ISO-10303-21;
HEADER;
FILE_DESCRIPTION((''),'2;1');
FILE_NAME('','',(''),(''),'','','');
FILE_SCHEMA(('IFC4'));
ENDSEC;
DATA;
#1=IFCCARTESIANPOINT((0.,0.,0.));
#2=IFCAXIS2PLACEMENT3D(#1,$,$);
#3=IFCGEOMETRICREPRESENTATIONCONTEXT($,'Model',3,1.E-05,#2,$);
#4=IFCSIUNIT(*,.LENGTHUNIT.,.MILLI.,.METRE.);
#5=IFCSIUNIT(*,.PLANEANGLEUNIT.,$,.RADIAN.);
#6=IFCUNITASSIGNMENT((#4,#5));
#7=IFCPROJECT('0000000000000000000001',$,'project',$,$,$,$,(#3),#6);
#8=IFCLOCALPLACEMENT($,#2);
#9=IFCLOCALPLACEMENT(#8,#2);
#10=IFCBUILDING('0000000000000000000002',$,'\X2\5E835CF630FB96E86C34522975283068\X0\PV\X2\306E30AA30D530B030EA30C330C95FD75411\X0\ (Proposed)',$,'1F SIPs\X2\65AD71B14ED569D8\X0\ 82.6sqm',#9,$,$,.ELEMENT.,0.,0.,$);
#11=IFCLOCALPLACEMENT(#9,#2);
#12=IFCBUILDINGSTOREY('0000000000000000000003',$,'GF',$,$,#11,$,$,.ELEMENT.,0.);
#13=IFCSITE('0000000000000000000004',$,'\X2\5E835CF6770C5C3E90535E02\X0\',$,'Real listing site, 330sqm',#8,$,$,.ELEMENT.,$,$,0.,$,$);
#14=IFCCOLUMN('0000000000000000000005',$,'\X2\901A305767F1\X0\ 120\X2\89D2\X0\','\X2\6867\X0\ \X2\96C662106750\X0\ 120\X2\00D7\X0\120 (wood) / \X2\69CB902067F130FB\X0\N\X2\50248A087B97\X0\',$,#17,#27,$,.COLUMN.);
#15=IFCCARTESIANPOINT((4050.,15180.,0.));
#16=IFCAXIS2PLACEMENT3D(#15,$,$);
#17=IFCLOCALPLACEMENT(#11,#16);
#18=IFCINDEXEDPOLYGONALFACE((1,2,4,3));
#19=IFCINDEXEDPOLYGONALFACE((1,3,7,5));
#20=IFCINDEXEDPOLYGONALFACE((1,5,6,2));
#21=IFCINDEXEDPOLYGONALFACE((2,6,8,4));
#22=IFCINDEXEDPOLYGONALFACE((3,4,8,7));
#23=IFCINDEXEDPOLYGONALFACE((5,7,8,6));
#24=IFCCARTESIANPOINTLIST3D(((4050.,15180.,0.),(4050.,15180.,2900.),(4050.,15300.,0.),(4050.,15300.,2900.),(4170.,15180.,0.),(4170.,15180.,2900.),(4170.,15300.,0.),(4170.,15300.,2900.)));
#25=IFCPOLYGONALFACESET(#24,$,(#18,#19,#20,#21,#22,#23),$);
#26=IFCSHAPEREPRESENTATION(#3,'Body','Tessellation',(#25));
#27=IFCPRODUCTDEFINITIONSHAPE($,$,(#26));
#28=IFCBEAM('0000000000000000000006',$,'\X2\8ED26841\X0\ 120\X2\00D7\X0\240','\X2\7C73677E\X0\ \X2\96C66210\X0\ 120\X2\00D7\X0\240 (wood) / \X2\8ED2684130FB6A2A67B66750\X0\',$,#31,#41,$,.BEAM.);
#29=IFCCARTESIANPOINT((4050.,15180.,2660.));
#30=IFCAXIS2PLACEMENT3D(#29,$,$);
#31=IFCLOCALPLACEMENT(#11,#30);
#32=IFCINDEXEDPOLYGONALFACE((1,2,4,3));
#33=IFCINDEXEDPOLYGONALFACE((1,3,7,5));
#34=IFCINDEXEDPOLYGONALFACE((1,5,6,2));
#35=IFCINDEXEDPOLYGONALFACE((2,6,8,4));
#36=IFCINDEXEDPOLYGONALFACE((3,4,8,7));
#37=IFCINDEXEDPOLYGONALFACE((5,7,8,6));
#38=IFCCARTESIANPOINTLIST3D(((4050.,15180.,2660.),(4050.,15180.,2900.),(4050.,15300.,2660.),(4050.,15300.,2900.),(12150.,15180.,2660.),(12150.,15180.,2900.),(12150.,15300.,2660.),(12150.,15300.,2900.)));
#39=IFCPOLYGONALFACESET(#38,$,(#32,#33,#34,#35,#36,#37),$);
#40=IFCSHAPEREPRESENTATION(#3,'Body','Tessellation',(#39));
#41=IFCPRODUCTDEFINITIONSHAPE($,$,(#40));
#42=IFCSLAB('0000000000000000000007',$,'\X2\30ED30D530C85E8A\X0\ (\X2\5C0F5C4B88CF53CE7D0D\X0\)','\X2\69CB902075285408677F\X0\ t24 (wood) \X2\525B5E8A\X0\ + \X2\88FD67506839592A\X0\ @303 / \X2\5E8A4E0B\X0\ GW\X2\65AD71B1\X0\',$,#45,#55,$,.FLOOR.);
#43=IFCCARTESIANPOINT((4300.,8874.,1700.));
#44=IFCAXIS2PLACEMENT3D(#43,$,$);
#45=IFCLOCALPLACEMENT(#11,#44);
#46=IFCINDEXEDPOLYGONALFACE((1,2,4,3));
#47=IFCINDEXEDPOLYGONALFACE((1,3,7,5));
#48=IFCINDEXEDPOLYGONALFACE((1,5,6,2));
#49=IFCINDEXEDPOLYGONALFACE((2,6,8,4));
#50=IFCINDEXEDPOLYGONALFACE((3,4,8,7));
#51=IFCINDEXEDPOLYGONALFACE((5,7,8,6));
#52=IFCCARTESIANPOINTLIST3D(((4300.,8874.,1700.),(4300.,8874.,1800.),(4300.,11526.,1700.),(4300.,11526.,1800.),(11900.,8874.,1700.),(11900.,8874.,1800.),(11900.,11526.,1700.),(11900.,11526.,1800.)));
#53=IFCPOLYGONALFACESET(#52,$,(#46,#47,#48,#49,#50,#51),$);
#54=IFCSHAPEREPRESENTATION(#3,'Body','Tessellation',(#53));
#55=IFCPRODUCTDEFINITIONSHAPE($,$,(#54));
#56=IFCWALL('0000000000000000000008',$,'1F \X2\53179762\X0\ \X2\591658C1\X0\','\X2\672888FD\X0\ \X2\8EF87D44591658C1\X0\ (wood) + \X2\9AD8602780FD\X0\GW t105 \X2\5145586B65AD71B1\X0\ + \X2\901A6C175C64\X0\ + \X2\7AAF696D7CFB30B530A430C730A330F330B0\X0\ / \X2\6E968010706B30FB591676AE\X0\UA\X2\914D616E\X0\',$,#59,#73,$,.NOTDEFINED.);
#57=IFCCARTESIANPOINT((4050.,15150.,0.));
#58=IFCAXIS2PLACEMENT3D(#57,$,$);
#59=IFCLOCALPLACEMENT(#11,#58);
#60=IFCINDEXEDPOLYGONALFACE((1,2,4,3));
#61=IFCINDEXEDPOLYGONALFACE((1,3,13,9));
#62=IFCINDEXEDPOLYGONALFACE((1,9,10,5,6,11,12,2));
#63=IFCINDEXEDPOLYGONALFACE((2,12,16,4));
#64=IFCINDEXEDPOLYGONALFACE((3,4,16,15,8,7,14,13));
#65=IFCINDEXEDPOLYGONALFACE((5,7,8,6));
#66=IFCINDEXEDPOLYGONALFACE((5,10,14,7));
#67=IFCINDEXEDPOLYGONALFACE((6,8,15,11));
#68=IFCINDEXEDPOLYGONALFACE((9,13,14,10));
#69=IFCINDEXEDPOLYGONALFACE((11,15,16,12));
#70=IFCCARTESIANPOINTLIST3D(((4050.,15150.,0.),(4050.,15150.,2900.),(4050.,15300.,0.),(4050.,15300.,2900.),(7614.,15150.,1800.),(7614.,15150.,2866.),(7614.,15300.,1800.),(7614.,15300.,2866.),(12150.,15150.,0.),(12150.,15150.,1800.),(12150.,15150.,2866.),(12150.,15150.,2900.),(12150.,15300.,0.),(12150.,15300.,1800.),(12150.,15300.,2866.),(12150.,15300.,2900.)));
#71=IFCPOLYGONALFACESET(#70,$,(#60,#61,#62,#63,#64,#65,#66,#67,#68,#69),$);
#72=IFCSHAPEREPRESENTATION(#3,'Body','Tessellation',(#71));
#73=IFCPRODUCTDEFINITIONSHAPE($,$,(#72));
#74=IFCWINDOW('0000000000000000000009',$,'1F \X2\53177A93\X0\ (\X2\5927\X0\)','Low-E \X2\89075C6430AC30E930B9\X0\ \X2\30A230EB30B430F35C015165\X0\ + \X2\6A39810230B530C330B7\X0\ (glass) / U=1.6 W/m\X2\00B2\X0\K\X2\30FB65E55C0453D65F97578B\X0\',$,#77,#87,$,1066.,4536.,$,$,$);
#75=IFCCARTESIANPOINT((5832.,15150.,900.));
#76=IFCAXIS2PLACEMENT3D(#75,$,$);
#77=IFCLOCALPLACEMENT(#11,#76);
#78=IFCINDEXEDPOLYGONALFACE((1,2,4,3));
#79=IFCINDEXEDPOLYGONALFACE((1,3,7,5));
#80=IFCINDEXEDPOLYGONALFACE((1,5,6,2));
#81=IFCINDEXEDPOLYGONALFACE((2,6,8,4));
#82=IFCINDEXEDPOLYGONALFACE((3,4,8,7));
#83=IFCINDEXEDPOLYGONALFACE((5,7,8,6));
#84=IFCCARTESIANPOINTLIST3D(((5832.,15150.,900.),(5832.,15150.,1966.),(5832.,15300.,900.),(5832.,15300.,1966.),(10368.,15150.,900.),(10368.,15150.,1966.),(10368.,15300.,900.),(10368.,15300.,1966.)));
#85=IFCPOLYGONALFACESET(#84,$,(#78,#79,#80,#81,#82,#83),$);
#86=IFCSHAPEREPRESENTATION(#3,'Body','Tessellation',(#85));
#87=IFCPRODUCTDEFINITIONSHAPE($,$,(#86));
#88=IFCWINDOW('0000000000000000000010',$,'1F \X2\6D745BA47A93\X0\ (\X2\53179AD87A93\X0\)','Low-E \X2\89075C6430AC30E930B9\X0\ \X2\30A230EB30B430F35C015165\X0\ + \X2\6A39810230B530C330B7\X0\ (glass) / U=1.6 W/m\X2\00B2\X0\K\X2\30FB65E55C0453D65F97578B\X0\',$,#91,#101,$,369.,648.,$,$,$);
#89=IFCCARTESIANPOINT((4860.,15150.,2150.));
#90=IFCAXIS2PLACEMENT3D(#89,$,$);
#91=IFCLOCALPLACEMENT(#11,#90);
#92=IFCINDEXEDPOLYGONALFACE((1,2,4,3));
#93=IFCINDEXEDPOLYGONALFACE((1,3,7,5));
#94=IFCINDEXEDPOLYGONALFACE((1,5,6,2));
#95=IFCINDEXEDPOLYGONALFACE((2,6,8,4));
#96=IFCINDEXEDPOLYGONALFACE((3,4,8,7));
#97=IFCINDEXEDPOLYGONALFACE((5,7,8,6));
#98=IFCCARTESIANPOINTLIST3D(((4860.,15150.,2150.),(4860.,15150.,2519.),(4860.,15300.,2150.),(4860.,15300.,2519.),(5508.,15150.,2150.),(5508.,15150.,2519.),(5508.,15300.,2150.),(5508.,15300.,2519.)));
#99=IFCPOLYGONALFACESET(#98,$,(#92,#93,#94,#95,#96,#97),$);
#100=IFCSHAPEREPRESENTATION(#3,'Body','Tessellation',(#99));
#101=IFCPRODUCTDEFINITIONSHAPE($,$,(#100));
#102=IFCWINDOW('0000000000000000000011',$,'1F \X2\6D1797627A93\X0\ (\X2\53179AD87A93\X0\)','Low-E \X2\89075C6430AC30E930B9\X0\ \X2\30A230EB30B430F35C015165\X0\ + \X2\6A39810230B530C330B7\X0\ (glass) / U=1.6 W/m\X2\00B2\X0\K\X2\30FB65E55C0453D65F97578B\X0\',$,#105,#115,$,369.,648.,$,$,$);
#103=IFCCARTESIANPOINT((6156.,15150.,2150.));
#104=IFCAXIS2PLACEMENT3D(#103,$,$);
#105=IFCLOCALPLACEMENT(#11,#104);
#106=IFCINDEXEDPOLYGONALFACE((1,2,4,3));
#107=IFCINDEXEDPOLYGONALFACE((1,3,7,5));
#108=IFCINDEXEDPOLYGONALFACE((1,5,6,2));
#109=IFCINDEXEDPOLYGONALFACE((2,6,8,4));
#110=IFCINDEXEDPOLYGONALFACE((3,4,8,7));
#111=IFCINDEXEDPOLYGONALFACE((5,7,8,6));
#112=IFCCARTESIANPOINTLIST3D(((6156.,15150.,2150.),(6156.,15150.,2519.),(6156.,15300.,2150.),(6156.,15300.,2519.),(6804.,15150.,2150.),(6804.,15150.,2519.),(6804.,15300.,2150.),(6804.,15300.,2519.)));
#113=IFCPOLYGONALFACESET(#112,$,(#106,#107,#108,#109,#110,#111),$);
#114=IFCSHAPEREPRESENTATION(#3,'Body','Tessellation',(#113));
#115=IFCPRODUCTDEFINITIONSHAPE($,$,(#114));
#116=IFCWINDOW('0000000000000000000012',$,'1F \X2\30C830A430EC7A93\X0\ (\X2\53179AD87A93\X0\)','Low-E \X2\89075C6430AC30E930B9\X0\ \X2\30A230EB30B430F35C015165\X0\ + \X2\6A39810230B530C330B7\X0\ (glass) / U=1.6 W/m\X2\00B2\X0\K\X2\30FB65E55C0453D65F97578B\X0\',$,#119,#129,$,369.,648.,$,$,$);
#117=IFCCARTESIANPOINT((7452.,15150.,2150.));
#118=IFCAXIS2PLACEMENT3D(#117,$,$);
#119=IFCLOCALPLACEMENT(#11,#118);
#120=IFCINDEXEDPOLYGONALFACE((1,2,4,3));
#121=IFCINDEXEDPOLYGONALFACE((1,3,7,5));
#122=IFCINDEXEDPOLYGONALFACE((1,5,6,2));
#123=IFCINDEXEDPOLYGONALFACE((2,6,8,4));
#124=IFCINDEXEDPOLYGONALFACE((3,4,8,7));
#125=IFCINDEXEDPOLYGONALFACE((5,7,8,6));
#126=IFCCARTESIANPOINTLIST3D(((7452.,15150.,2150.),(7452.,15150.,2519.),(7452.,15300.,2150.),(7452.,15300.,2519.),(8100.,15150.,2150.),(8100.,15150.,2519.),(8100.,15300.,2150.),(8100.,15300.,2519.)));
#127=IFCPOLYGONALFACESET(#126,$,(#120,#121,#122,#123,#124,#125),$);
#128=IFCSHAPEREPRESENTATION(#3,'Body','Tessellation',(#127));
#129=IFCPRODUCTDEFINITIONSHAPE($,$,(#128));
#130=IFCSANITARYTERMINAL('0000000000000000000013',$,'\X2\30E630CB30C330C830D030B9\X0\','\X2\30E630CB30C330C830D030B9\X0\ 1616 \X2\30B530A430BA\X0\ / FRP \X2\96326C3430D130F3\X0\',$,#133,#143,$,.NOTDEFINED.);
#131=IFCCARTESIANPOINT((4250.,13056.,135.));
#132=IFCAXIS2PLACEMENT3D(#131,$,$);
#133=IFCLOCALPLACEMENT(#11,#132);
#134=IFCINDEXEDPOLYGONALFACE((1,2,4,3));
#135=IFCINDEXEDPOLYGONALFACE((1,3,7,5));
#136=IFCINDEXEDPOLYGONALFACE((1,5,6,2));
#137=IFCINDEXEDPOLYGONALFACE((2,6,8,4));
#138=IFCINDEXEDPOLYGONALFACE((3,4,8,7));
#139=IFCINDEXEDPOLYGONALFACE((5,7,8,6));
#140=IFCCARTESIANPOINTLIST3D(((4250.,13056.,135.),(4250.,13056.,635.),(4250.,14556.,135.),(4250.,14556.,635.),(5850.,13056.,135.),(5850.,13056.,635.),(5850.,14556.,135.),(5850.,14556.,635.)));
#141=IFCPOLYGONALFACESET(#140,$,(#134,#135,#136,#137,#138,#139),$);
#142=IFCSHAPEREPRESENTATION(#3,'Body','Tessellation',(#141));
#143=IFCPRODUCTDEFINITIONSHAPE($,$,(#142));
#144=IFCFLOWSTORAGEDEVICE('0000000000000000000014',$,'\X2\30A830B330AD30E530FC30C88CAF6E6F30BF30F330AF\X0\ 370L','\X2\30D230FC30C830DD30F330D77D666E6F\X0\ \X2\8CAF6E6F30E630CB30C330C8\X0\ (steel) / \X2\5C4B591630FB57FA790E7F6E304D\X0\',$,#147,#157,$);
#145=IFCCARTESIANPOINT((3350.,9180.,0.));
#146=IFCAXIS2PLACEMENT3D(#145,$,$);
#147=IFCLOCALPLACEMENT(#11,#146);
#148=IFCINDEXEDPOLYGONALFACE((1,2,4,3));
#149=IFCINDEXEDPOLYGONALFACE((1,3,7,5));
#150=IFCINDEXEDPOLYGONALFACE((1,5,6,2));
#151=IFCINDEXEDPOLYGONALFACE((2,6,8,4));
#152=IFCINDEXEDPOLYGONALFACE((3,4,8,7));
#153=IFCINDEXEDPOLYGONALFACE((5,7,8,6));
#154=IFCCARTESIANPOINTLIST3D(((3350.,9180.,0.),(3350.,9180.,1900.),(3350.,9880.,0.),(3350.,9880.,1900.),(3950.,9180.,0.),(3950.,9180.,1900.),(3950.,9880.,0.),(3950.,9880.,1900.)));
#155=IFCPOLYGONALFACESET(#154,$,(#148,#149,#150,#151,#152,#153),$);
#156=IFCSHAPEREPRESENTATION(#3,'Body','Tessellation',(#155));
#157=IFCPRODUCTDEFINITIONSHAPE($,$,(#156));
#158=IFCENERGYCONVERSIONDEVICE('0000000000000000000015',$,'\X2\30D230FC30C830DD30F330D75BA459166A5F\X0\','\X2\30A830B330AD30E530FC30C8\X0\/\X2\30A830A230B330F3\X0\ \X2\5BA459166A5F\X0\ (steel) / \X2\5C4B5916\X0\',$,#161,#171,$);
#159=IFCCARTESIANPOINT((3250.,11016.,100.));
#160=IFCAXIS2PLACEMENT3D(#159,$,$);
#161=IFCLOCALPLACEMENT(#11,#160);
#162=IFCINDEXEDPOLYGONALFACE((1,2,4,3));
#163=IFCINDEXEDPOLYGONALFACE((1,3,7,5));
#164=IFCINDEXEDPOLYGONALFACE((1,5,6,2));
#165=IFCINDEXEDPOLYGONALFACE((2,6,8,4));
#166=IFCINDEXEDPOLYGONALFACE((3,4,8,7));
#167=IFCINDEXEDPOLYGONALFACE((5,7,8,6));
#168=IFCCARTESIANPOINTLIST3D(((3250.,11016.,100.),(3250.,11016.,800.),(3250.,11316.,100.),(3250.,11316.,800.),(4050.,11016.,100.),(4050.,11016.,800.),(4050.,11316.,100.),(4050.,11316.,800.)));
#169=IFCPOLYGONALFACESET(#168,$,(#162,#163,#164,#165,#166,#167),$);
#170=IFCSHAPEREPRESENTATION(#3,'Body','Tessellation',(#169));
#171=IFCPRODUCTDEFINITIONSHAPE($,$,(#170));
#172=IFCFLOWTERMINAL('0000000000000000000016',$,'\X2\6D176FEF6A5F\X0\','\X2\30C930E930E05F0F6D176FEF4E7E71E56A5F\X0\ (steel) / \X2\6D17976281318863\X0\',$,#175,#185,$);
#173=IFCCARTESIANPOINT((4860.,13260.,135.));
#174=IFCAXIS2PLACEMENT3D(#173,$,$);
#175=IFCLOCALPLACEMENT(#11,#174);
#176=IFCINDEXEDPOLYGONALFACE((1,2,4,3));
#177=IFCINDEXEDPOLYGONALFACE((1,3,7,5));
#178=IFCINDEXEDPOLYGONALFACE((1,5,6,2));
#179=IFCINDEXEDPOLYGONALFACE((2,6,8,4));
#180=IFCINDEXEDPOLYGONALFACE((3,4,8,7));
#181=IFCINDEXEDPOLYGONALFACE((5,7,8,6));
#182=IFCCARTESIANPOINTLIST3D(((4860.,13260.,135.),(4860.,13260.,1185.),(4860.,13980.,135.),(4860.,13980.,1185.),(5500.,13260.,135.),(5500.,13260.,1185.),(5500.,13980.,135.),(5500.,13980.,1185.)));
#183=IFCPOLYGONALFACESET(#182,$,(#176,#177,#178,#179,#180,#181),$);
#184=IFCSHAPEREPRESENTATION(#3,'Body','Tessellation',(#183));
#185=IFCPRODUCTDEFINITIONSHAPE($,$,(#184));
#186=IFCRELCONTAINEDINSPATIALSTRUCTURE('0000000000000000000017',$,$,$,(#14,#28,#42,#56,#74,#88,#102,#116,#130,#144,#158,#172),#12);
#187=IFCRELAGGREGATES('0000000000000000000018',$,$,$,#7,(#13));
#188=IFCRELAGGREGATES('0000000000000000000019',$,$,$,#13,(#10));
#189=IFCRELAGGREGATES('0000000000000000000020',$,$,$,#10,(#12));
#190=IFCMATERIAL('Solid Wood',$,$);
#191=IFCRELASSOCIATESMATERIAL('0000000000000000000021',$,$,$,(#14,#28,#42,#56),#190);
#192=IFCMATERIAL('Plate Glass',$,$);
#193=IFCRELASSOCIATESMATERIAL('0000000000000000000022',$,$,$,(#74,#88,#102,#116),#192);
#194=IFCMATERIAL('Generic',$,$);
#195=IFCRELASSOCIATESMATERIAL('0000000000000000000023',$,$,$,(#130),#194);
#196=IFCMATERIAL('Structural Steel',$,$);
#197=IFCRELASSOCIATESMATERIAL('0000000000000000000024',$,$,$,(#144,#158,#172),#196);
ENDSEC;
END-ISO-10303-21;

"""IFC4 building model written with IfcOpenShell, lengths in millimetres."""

from ifc_helpers import new_model, si_unit, frame, frame_2d, origin, place, context, project, spatial, rectangle, extrude, material, element, fill, save


model = new_model("IFC4")

# Units and contexts
model_context = context("Model", 3, precision=1e-05, world=origin())
ifc_project = project(units=[si_unit("LENGTHUNIT", "METRE", prefix="MILLI"), si_unit("PLANEANGLEUNIT", "RADIAN")], contexts=[model_context])

# Site, building, storey
site_placement = place(None, origin())
site = spatial("IfcSite", under=ifc_project, at=site_placement, Name="広島県尾道市", ObjectType="Real listing site, 330sqm", CompositionType="ELEMENT", RefElevation=0.0)
building_placement = place(site_placement, origin())
building = spatial("IfcBuilding", under=site, at=building_placement, Name="広島・雨水利用とPVのオフグリッド志向 (Proposed)", ObjectType="1F SIPs断熱仕様 82.6sqm", CompositionType="ELEMENT", ElevationOfRefHeight=0.0, ElevationOfTerrain=0.0)
storey_placement = place(building_placement, origin())
storey = spatial("IfcBuildingStorey", under=building, at=storey_placement, Name="GF", CompositionType="ELEMENT", Elevation=0.0)

# Column
ifc_material_1 = material(Name="Solid Wood")
column_1_placement = place(storey_placement, frame((4050.0, 15180.0, 0.0)))
element("IfcColumn", 1, at=column_1_placement, inside=storey, material=ifc_material_1, Name="通し柱 120角", Description="桧 集成材 120×120 (wood) / 構造柱・N値計算", PredefinedType="COLUMN", context=model_context, shape_type="SweptSolid", body=[
    extrude(rectangle(XDim=120.0, YDim=120.0, at=frame_2d((60.0, 60.0))), frame((4050.0, 15180.0, 0.0)), (0.0, 0.0, 1.0), 2900.0),
])

# Beam
beam_1_placement = place(storey_placement, frame((4050.0, 15180.0, 2660.0)))
element("IfcBeam", 2, at=beam_1_placement, inside=storey, material=ifc_material_1, Name="軒桁 120×240", Description="米松 集成 120×240 (wood) / 軒桁・横架材", PredefinedType="BEAM", context=model_context, shape_type="SweptSolid", body=[
    extrude(rectangle(XDim=8100.0, YDim=120.0, at=frame_2d((4050.0, 60.0))), frame((4050.0, 15180.0, 2660.0)), (0.0, 0.0, 1.0), 240.0),
])

# Slab
slab_placement = place(storey_placement, frame((4300.0, 8874.0, 1700.0)))
element("IfcSlab", 3, at=slab_placement, inside=storey, material=ifc_material_1, Name="ロフト床 (小屋裏収納)", Description="構造用合板 t24 (wood) 剛床 + 製材根太 @303 / 床下 GW断熱", PredefinedType="FLOOR", context=model_context, shape_type="SweptSolid", body=[
    extrude(rectangle(XDim=7600.0, YDim=2652.0, at=frame_2d((3800.0, 1326.0))), frame((4300.0, 8874.0, 1700.0)), (0.0, 0.0, 1.0), 100.0),
])

# Wall, openings, windows
wall_1_placement = place(storey_placement, frame((4050.0, 15150.0, 0.0)))
wall_1 = element("IfcWall", 4, at=wall_1_placement, inside=storey, material=ifc_material_1, Name="1F 北面 外壁", Description="木製 軸組外壁 (wood) + 高性能GW t105 充填断熱 + 通気層 + 窯業系サイディング / 準耐火・外皮UA配慮", PredefinedType="NOTDEFINED", context=model_context, shape_type="SweptSolid", body=[
    extrude(rectangle(XDim=8100.0, YDim=150.0, at=frame_2d((4050.0, 75.0))), frame((4050.0, 15150.0, 0.0)), (0.0, 0.0, 1.0), 2900.0),
])
opening_1_placement = place(storey_placement, frame((5832.0, 15150.0, 900.0)))
opening_1 = element("IfcOpeningElement", 5, at=opening_1_placement, cuts=wall_1, PredefinedType="NOTDEFINED", context=model_context, shape_type="SweptSolid", body=[
    extrude(rectangle(XDim=4536.0, YDim=150.0, at=frame_2d((2268.0, 75.0))), frame((5832.0, 15150.0, 900.0)), (0.0, 0.0, 1.0), 1066.0),
])
opening_2_placement = place(storey_placement, frame((4860.0, 15150.0, 2150.0)))
opening_2 = element("IfcOpeningElement", 6, at=opening_2_placement, cuts=wall_1, PredefinedType="NOTDEFINED", context=model_context, shape_type="SweptSolid", body=[
    extrude(rectangle(XDim=648.0, YDim=150.0, at=frame_2d((324.0, 75.0))), frame((4860.0, 15150.0, 2150.0)), (0.0, 0.0, 1.0), 369.0),
])
opening_3_placement = place(storey_placement, frame((6156.0, 15150.0, 2150.0)))
opening_3 = element("IfcOpeningElement", 7, at=opening_3_placement, cuts=wall_1, PredefinedType="NOTDEFINED", context=model_context, shape_type="SweptSolid", body=[
    extrude(rectangle(XDim=648.0, YDim=150.0, at=frame_2d((324.0, 75.0))), frame((6156.0, 15150.0, 2150.0)), (0.0, 0.0, 1.0), 369.0),
])
opening_4_placement = place(storey_placement, frame((7452.0, 15150.0, 2150.0)))
opening_4 = element("IfcOpeningElement", 8, at=opening_4_placement, cuts=wall_1, PredefinedType="NOTDEFINED", context=model_context, shape_type="SweptSolid", body=[
    extrude(rectangle(XDim=648.0, YDim=150.0, at=frame_2d((324.0, 75.0))), frame((7452.0, 15150.0, 2150.0)), (0.0, 0.0, 1.0), 369.0),
])
ifc_material_2 = material(Name="Plate Glass")
window_1_placement = place(storey_placement, frame((5832.0, 15150.0, 900.0)))
window_1 = element("IfcWindow", 9, at=window_1_placement, inside=storey, material=ifc_material_2, Name="1F 北窓 (大)", Description="Low-E 複層ガラス アルゴン封入 + 樹脂サッシ (glass) / U=1.6 W/m²K・日射取得型", OverallHeight=1066.0, OverallWidth=4536.0, context=model_context, shape_type="SweptSolid", body=[
    extrude(rectangle(XDim=4536.0, YDim=150.0, at=frame_2d((2268.0, 75.0))), frame((5832.0, 15150.0, 900.0)), (0.0, 0.0, 1.0), 1066.0),
])
fill(opening_1, window_1)
window_2_placement = place(storey_placement, frame((4860.0, 15150.0, 2150.0)))
window_2 = element("IfcWindow", 10, at=window_2_placement, inside=storey, material=ifc_material_2, Name="1F 浴室窓 (北高窓)", Description="Low-E 複層ガラス アルゴン封入 + 樹脂サッシ (glass) / U=1.6 W/m²K・日射取得型", OverallHeight=369.0, OverallWidth=648.0, context=model_context, shape_type="SweptSolid", body=[
    extrude(rectangle(XDim=648.0, YDim=150.0, at=frame_2d((324.0, 75.0))), frame((4860.0, 15150.0, 2150.0)), (0.0, 0.0, 1.0), 369.0),
])
fill(opening_2, window_2)
window_3_placement = place(storey_placement, frame((6156.0, 15150.0, 2150.0)))
window_3 = element("IfcWindow", 11, at=window_3_placement, inside=storey, material=ifc_material_2, Name="1F 洗面窓 (北高窓)", Description="Low-E 複層ガラス アルゴン封入 + 樹脂サッシ (glass) / U=1.6 W/m²K・日射取得型", OverallHeight=369.0, OverallWidth=648.0, context=model_context, shape_type="SweptSolid", body=[
    extrude(rectangle(XDim=648.0, YDim=150.0, at=frame_2d((324.0, 75.0))), frame((6156.0, 15150.0, 2150.0)), (0.0, 0.0, 1.0), 369.0),
])
fill(opening_3, window_3)
window_4_placement = place(storey_placement, frame((7452.0, 15150.0, 2150.0)))
window_4 = element("IfcWindow", 12, at=window_4_placement, inside=storey, material=ifc_material_2, Name="1F トイレ窓 (北高窓)", Description="Low-E 複層ガラス アルゴン封入 + 樹脂サッシ (glass) / U=1.6 W/m²K・日射取得型", OverallHeight=369.0, OverallWidth=648.0, context=model_context, shape_type="SweptSolid", body=[
    extrude(rectangle(XDim=648.0, YDim=150.0, at=frame_2d((324.0, 75.0))), frame((7452.0, 15150.0, 2150.0)), (0.0, 0.0, 1.0), 369.0),
])
fill(opening_4, window_4)

# Sanitary terminal
ifc_material_3 = material(Name="Generic")
sanitary_terminal_placement = place(storey_placement, frame((4250.0, 13056.0, 135.0)))
element("IfcSanitaryTerminal", 13, at=sanitary_terminal_placement, inside=storey, material=ifc_material_3, Name="ユニットバス", Description="ユニットバス 1616 サイズ / FRP 防水パン", PredefinedType="NOTDEFINED", context=model_context, shape_type="SweptSolid", body=[
    extrude(rectangle(XDim=1600.0, YDim=1500.0, at=frame_2d((800.0, 750.0))), frame((4250.0, 13056.0, 135.0)), (0.0, 0.0, 1.0), 500.0),
])

# Flow storage device
ifc_material_4 = material(Name="Structural Steel")
flow_storage_device_placement = place(storey_placement, frame((3350.0, 9180.0, 0.0)))
element("IfcFlowStorageDevice", 14, at=flow_storage_device_placement, inside=storey, material=ifc_material_4, Name="エコキュート貯湯タンク 370L", Description="ヒートポンプ給湯 貯湯ユニット (steel) / 屋外・基礎置き", context=model_context, shape_type="SweptSolid", body=[
    extrude(rectangle(XDim=600.0, YDim=700.0, at=frame_2d((300.0, 350.0))), frame((3350.0, 9180.0, 0.0)), (0.0, 0.0, 1.0), 1900.0),
])

# Energy conversion device
energy_conversion_device_placement = place(storey_placement, frame((3250.0, 11016.0, 100.0)))
element("IfcEnergyConversionDevice", 15, at=energy_conversion_device_placement, inside=storey, material=ifc_material_4, Name="ヒートポンプ室外機", Description="エコキュート/エアコン 室外機 (steel) / 屋外", context=model_context, shape_type="SweptSolid", body=[
    extrude(rectangle(XDim=800.0, YDim=300.0, at=frame_2d((400.0, 150.0))), frame((3250.0, 11016.0, 100.0)), (0.0, 0.0, 1.0), 700.0),
])

# Flow terminal
flow_terminal_placement = place(storey_placement, frame((4860.0, 13260.0, 135.0)))
element("IfcFlowTerminal", 16, at=flow_terminal_placement, inside=storey, material=ifc_material_4, Name="洗濯機", Description="ドラム式洗濯乾燥機 (steel) / 洗面脱衣", context=model_context, shape_type="SweptSolid", body=[
    extrude(rectangle(XDim=640.0, YDim=720.0, at=frame_2d((320.0, 360.0))), frame((4860.0, 13260.0, 135.0)), (0.0, 0.0, 1.0), 1050.0),
])

save(model, "model.ifc")
